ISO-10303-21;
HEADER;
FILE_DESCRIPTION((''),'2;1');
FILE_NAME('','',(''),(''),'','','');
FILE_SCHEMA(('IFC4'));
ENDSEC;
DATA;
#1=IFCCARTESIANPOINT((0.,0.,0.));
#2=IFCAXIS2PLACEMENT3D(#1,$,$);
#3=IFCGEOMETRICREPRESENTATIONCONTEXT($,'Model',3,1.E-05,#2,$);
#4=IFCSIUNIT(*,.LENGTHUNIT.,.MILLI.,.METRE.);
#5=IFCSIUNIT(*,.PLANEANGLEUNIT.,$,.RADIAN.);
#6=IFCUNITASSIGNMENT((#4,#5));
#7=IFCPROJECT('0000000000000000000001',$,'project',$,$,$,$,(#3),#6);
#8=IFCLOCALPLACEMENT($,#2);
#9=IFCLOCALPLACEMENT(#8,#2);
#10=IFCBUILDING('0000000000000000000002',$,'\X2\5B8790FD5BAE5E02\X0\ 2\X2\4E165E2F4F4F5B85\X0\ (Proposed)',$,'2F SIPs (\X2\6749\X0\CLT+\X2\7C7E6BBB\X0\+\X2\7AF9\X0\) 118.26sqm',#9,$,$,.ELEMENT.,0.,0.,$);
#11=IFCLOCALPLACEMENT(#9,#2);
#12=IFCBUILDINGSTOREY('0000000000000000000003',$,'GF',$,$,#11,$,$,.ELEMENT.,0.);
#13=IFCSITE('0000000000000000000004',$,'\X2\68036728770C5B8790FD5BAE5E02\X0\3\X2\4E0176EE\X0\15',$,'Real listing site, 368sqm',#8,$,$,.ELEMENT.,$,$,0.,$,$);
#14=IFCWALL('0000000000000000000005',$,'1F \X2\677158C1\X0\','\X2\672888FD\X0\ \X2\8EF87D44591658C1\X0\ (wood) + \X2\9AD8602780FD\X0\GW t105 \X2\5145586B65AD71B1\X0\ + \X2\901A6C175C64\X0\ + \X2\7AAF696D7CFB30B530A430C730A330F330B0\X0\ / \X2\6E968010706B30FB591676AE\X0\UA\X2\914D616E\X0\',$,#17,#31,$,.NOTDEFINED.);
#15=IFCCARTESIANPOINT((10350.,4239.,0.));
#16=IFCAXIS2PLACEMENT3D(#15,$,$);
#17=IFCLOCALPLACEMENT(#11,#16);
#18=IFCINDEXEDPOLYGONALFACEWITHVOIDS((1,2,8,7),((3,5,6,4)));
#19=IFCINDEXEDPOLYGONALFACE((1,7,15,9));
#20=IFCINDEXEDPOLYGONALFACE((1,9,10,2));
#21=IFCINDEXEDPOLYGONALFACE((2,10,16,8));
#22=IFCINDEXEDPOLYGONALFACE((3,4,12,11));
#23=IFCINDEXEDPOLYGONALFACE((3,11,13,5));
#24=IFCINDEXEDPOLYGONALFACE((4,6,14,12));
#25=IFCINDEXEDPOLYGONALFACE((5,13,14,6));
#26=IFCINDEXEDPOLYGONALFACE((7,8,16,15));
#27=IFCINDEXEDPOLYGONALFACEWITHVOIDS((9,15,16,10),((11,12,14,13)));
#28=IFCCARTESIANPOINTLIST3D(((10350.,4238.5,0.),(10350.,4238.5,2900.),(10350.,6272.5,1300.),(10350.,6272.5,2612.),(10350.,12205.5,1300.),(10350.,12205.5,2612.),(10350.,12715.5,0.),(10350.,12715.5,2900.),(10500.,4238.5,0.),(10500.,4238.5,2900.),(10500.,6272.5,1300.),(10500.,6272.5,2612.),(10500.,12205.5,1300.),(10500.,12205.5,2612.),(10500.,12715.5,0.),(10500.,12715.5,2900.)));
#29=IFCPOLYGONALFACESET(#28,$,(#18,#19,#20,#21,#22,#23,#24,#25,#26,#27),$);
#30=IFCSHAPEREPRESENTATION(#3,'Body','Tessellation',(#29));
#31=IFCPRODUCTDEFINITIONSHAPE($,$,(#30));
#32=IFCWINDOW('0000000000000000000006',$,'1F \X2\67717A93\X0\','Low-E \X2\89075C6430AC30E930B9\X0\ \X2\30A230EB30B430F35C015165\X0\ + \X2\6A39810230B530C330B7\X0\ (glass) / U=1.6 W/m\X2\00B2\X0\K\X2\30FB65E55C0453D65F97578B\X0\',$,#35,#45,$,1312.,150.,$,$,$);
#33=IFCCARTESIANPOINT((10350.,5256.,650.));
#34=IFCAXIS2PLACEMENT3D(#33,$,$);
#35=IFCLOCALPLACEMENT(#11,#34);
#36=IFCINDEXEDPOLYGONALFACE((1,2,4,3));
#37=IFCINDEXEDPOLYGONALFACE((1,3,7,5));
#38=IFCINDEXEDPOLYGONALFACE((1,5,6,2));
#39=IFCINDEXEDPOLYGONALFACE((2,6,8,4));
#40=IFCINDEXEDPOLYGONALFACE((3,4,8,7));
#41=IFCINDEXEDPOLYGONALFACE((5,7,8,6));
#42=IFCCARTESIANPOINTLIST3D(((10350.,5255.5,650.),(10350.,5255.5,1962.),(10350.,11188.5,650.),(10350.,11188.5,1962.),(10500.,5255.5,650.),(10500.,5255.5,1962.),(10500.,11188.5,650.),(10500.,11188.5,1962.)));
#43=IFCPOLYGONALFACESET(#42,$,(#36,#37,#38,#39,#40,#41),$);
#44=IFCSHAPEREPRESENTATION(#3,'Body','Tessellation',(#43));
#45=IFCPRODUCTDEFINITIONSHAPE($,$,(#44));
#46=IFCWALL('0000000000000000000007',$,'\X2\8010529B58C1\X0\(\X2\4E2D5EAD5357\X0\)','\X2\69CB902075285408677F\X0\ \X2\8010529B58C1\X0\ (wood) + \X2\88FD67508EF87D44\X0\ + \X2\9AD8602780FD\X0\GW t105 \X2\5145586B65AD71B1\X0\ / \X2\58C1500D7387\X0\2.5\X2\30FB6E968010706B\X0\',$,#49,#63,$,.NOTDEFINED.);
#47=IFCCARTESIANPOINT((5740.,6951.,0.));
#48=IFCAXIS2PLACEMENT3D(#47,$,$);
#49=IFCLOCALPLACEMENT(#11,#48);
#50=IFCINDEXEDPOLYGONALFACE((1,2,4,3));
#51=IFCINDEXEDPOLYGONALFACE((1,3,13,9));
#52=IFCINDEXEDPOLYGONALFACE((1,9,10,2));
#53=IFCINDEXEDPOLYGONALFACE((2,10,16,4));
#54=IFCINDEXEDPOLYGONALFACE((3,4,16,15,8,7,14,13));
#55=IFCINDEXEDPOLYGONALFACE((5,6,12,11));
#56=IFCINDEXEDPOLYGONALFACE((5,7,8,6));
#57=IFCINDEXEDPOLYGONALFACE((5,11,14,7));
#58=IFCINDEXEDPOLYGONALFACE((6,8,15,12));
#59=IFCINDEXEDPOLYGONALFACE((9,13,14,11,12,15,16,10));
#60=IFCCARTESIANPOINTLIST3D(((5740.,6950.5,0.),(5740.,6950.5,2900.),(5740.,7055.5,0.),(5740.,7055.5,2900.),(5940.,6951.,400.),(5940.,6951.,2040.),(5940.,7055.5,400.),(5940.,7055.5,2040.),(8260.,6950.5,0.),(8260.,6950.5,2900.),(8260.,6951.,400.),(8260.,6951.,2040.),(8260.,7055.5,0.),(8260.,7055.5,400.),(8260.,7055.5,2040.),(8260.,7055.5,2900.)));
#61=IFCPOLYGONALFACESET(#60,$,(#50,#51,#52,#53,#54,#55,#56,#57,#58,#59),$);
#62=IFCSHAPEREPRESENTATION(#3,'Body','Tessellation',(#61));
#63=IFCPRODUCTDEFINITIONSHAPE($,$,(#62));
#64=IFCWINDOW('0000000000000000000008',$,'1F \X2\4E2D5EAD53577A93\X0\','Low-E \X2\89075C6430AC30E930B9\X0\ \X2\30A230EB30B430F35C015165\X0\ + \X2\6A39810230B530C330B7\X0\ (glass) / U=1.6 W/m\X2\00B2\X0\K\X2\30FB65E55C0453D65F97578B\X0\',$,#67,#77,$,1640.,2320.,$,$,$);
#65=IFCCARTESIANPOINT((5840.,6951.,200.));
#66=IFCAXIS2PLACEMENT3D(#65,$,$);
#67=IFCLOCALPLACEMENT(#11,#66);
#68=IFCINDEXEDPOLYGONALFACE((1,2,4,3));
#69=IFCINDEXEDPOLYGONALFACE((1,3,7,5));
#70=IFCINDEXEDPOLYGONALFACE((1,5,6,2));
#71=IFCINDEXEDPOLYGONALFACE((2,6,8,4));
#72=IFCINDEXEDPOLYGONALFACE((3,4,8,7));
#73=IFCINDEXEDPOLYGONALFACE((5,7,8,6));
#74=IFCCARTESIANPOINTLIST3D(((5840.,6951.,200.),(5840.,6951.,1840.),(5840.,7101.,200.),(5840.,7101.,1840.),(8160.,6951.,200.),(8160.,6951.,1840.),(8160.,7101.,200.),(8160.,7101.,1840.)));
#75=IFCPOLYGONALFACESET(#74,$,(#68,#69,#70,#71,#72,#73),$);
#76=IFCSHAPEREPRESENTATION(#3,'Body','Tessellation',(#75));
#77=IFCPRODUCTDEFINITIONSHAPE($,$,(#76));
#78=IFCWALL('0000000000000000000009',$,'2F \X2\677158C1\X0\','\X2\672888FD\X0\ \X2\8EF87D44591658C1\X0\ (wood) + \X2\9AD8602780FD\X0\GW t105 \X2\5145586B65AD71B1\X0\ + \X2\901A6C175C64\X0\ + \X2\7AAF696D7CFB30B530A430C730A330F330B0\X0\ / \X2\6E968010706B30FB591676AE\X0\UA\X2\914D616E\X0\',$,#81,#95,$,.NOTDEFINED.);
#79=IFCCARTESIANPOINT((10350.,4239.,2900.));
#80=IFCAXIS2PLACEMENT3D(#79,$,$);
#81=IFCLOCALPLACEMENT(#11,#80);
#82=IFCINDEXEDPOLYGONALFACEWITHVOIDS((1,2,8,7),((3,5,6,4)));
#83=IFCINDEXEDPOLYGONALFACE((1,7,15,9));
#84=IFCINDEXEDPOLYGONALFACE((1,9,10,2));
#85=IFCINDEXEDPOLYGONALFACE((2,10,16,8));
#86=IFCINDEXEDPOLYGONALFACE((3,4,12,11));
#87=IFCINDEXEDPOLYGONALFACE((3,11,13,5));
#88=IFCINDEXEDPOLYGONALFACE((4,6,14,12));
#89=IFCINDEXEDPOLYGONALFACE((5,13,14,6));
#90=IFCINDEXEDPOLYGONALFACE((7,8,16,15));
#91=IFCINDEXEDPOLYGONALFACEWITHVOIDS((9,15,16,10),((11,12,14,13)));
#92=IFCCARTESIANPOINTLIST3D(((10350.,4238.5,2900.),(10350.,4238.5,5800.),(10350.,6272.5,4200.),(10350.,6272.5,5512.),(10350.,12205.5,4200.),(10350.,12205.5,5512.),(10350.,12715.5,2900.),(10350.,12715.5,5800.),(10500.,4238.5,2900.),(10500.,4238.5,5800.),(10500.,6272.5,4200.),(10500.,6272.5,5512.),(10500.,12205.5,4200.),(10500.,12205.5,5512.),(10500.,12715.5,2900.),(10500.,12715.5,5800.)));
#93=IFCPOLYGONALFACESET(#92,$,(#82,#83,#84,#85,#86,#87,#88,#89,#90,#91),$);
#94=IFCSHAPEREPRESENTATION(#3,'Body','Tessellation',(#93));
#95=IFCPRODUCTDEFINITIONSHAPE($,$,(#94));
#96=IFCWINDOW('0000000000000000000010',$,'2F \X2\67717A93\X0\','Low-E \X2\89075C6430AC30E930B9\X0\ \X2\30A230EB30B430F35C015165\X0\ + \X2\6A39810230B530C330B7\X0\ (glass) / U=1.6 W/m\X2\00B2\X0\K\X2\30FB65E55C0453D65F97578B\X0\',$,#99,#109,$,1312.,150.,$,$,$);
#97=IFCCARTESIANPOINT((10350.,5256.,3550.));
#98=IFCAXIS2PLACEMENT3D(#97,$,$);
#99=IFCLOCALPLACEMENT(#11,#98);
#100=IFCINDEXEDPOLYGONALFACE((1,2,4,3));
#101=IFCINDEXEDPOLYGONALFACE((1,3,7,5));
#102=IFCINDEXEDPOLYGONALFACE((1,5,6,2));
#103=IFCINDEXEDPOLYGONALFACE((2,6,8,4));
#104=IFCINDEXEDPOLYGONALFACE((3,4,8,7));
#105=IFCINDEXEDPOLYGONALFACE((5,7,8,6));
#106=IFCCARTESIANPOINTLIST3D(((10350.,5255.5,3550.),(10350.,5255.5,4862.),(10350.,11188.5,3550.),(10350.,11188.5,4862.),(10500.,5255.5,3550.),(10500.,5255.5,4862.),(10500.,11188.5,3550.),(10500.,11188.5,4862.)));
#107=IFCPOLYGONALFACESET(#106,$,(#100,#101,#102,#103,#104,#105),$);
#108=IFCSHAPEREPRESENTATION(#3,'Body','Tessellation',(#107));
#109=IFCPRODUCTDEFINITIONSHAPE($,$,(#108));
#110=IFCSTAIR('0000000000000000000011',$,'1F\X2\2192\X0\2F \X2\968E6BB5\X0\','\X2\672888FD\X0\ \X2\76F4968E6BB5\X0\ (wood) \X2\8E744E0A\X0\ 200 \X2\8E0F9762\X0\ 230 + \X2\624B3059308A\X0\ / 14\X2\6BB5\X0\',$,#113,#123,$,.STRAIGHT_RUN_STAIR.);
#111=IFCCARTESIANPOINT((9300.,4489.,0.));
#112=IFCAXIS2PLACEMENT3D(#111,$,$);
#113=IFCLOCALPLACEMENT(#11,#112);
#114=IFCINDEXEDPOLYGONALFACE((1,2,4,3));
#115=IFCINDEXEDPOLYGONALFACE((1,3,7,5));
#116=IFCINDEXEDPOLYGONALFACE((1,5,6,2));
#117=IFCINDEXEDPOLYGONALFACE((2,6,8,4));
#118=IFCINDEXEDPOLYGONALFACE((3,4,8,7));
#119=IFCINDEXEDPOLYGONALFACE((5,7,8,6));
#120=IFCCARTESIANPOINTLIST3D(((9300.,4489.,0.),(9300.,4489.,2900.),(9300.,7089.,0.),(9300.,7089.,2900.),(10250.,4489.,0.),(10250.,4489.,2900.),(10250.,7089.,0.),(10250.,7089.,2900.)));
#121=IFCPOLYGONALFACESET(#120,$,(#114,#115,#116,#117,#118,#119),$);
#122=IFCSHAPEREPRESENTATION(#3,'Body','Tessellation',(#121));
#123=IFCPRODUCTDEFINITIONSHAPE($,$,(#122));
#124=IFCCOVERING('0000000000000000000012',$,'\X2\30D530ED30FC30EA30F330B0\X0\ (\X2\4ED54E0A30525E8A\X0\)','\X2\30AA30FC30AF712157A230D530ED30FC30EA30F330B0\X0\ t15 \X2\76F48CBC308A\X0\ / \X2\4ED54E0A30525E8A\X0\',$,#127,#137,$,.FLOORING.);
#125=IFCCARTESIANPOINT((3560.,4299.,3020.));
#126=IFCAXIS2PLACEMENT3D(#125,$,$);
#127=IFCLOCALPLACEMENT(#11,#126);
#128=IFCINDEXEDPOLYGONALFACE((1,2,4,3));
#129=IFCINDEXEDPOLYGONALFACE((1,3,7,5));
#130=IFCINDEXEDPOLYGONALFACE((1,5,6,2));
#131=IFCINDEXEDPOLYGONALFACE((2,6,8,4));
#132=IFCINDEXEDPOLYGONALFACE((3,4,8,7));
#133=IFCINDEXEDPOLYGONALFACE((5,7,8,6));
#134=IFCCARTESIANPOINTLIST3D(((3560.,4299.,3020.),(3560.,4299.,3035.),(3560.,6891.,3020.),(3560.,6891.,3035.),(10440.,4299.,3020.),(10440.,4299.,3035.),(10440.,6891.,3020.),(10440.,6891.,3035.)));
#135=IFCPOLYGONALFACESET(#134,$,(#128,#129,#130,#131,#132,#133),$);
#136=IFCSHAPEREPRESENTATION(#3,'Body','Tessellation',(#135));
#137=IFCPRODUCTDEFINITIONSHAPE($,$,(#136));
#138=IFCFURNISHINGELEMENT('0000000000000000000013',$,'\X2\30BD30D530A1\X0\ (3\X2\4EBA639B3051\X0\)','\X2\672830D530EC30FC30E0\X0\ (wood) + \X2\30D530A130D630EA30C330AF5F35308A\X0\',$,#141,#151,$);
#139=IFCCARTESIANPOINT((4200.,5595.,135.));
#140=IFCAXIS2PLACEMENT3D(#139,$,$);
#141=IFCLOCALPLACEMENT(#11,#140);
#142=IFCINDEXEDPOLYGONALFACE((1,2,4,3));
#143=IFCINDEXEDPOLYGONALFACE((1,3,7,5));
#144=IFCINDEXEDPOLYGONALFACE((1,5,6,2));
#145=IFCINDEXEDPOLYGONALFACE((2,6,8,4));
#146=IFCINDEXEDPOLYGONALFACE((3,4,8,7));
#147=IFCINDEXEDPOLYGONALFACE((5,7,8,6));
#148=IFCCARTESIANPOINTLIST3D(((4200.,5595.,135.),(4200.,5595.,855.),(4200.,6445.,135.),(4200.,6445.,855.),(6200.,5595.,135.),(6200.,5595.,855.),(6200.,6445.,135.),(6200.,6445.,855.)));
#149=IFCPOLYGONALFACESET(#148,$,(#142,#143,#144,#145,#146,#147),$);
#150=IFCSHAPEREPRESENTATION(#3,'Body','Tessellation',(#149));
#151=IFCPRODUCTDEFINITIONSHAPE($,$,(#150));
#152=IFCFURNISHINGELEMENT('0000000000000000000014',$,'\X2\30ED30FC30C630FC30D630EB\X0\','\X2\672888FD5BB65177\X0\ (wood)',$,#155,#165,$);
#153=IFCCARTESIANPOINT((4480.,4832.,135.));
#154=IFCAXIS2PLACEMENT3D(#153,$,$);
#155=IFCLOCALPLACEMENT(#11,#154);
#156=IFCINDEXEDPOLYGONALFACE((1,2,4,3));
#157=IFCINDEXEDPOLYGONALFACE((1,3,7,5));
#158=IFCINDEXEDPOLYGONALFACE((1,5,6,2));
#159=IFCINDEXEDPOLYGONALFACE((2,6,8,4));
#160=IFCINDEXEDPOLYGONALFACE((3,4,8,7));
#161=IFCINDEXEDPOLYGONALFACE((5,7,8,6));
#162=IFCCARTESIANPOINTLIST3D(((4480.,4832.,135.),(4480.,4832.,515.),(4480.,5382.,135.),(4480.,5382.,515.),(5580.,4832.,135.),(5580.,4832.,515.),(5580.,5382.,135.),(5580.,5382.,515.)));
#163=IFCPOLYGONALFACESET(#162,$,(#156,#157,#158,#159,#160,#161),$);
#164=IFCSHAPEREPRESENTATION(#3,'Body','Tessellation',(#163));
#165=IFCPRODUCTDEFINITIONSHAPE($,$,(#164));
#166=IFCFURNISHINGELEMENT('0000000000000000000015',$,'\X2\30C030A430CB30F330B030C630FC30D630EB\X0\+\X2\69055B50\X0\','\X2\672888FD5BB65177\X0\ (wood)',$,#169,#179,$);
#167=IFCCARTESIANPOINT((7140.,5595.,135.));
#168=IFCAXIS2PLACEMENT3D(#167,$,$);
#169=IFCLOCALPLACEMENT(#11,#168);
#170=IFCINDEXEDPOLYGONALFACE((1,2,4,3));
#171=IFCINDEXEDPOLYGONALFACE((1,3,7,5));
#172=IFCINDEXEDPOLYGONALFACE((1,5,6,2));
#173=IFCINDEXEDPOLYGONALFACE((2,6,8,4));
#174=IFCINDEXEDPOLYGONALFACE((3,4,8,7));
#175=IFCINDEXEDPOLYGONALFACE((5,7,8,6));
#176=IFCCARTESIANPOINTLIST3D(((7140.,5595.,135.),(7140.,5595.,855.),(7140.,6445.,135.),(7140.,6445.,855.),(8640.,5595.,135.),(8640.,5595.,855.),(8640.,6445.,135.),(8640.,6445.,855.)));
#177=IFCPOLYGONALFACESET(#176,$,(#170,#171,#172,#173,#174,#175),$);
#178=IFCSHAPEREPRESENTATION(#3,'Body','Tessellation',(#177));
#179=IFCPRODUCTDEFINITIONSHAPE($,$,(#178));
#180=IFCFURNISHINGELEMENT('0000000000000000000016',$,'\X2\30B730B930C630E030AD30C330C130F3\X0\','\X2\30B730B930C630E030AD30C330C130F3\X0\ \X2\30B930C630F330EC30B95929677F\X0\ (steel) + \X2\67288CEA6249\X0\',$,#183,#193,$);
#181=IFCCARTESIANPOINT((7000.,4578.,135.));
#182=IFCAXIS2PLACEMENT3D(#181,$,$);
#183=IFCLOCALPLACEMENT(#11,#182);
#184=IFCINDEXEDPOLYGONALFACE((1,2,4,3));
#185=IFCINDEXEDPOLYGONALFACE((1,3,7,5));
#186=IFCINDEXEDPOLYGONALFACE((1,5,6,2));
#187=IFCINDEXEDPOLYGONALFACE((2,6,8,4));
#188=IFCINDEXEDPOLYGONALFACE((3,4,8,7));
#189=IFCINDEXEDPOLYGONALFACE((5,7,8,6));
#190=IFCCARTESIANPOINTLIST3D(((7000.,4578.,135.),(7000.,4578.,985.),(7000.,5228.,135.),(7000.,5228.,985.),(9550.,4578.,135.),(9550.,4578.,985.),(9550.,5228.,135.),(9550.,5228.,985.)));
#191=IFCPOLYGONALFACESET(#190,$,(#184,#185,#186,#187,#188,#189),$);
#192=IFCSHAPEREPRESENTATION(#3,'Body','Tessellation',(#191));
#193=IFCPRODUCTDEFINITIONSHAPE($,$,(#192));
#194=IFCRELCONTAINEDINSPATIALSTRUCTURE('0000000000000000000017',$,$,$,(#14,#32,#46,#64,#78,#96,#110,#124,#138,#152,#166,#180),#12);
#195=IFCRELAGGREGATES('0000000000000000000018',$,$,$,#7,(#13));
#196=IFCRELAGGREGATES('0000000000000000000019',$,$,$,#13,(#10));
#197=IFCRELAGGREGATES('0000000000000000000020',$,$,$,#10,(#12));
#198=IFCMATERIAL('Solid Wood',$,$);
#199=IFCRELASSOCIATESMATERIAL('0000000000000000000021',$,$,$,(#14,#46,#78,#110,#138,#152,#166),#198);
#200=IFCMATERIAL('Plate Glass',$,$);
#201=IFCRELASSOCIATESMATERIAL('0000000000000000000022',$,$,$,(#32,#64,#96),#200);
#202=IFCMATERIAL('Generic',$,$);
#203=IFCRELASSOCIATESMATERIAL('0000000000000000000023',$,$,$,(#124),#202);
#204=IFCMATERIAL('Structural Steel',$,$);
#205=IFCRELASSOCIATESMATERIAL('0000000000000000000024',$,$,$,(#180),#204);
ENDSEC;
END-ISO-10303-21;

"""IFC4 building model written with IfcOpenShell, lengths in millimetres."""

from ifc_helpers import new_model, si_unit, frame, frame_2d, origin, place, context, project, spatial, rectangle, extrude, material, element, fill, save


model = new_model("IFC4")

# Units and contexts
model_context = context("Model", 3, precision=1e-05, world=origin())
ifc_project = project(units=[si_unit("LENGTHUNIT", "METRE", prefix="MILLI"), si_unit("PLANEANGLEUNIT", "RADIAN")], contexts=[model_context])

# Site, building, storey
site_placement = place(None, origin())
site = spatial("IfcSite", under=ifc_project, at=site_placement, Name="栃木県宇都宮市3丁目15", ObjectType="Real listing site, 368sqm", CompositionType="ELEMENT", RefElevation=0.0)
building_placement = place(site_placement, origin())
building = spatial("IfcBuilding", under=site, at=building_placement, Name="宇都宮市 2世帯住宅 (Proposed)", ObjectType="2F SIPs (杉CLT+籾殻+竹) 118.26sqm", CompositionType="ELEMENT", ElevationOfRefHeight=0.0, ElevationOfTerrain=0.0)
storey_placement = place(building_placement, origin())
storey = spatial("IfcBuildingStorey", under=building, at=storey_placement, Name="GF", CompositionType="ELEMENT", Elevation=0.0)

# Shared definitions
ifc_material_1 = material(Name="Solid Wood")

# Walls, openings, windows
wall_1_placement = place(storey_placement, frame((10350.0, 4239.0, 0.0)))
wall_1 = element("IfcWall", 1, at=wall_1_placement, inside=storey, material=ifc_material_1, Name="1F 東壁", Description="木製 軸組外壁 (wood) + 高性能GW t105 充填断熱 + 通気層 + 窯業系サイディング / 準耐火・外皮UA配慮", PredefinedType="NOTDEFINED", context=model_context, shape_type="SweptSolid", body=[
    extrude(rectangle(XDim=150.0, YDim=8477.0, at=frame_2d((75.0, 4238.0))), frame((10350.0, 4239.0, 0.0)), (0.0, 0.0, 1.0), 2900.0),
])
opening_1_placement = place(storey_placement, frame((10350.0, 5256.0, 650.0)))
opening_1 = element("IfcOpeningElement", 2, at=opening_1_placement, cuts=wall_1, PredefinedType="NOTDEFINED", context=model_context, shape_type="SweptSolid", body=[
    extrude(rectangle(XDim=150.0, YDim=5933.0, at=frame_2d((75.0, 2966.0))), frame((10350.0, 5256.0, 650.0)), (0.0, 0.0, 1.0), 1312.0),
])
ifc_material_2 = material(Name="Plate Glass")
window_1_placement = place(storey_placement, frame((10350.0, 5256.0, 650.0)))
window_1 = element("IfcWindow", 3, at=window_1_placement, inside=storey, material=ifc_material_2, Name="1F 東窓", Description="Low-E 複層ガラス アルゴン封入 + 樹脂サッシ (glass) / U=1.6 W/m²K・日射取得型", OverallHeight=1312.0, OverallWidth=150.0, context=model_context, shape_type="SweptSolid", body=[
    extrude(rectangle(XDim=150.0, YDim=5933.0, at=frame_2d((75.0, 2966.0))), frame((10350.0, 5256.0, 650.0)), (0.0, 0.0, 1.0), 1312.0),
])
fill(opening_1, window_1)
wall_2_placement = place(storey_placement, frame((5740.0, 6951.0, 0.0)))
wall_2 = element("IfcWall", 4, at=wall_2_placement, inside=storey, material=ifc_material_1, Name="耐力壁(中庭南)", Description="構造用合板 耐力壁 (wood) + 製材軸組 + 高性能GW t105 充填断熱 / 壁倍率2.5・準耐火", PredefinedType="NOTDEFINED", context=model_context, shape_type="SweptSolid", body=[
    extrude(rectangle(XDim=2520.0, YDim=105.0, at=frame_2d((1260.0, 52.0))), frame((5740.0, 6951.0, 0.0)), (0.0, 0.0, 1.0), 2900.0),
])
opening_2_placement = place(storey_placement, frame((5840.0, 6951.0, 200.0)))
opening_2 = element("IfcOpeningElement", 5, at=opening_2_placement, cuts=wall_2, PredefinedType="NOTDEFINED", context=model_context, shape_type="SweptSolid", body=[
    extrude(rectangle(XDim=2320.0, YDim=150.0, at=frame_2d((1160.0, 75.0))), frame((5840.0, 6951.0, 200.0)), (0.0, 0.0, 1.0), 1640.0),
])
window_2_placement = place(storey_placement, frame((5840.0, 6951.0, 200.0)))
window_2 = element("IfcWindow", 6, at=window_2_placement, inside=storey, material=ifc_material_2, Name="1F 中庭南窓", Description="Low-E 複層ガラス アルゴン封入 + 樹脂サッシ (glass) / U=1.6 W/m²K・日射取得型", OverallHeight=1640.0, OverallWidth=2320.0, context=model_context, shape_type="SweptSolid", body=[
    extrude(rectangle(XDim=2320.0, YDim=150.0, at=frame_2d((1160.0, 75.0))), frame((5840.0, 6951.0, 200.0)), (0.0, 0.0, 1.0), 1640.0),
])
fill(opening_2, window_2)

# Wall, opening, window
wall_3_placement = place(storey_placement, frame((10350.0, 4239.0, 2900.0)))
wall_3 = element("IfcWall", 7, at=wall_3_placement, inside=storey, material=ifc_material_1, Name="2F 東壁", Description="木製 軸組外壁 (wood) + 高性能GW t105 充填断熱 + 通気層 + 窯業系サイディング / 準耐火・外皮UA配慮", PredefinedType="NOTDEFINED", context=model_context, shape_type="SweptSolid", body=[
    extrude(rectangle(XDim=150.0, YDim=8477.0, at=frame_2d((75.0, 4238.0))), frame((10350.0, 4239.0, 2900.0)), (0.0, 0.0, 1.0), 2900.0),
])
opening_3_placement = place(storey_placement, frame((10350.0, 5256.0, 3550.0)))
opening_3 = element("IfcOpeningElement", 8, at=opening_3_placement, cuts=wall_3, PredefinedType="NOTDEFINED", context=model_context, shape_type="SweptSolid", body=[
    extrude(rectangle(XDim=150.0, YDim=5933.0, at=frame_2d((75.0, 2966.0))), frame((10350.0, 5256.0, 3550.0)), (0.0, 0.0, 1.0), 1312.0),
])
window_3_placement = place(storey_placement, frame((10350.0, 5256.0, 3550.0)))
window_3 = element("IfcWindow", 9, at=window_3_placement, inside=storey, material=ifc_material_2, Name="2F 東窓", Description="Low-E 複層ガラス アルゴン封入 + 樹脂サッシ (glass) / U=1.6 W/m²K・日射取得型", OverallHeight=1312.0, OverallWidth=150.0, context=model_context, shape_type="SweptSolid", body=[
    extrude(rectangle(XDim=150.0, YDim=5933.0, at=frame_2d((75.0, 2966.0))), frame((10350.0, 5256.0, 3550.0)), (0.0, 0.0, 1.0), 1312.0),
])
fill(opening_3, window_3)

# Stair
stair_placement = place(storey_placement, frame((9300.0, 4489.0, 0.0)))
element("IfcStair", 10, at=stair_placement, inside=storey, material=ifc_material_1, Name="1F→2F 階段", Description="木製 直階段 (wood) 蹴上 200 踏面 230 + 手すり / 14段", PredefinedType="STRAIGHT_RUN_STAIR", context=model_context, shape_type="SweptSolid", body=[
    extrude(rectangle(XDim=950.0, YDim=2600.0, at=frame_2d((475.0, 1300.0))), frame((9300.0, 4489.0, 0.0)), (0.0, 0.0, 1.0), 2900.0),
])

# Covering
ifc_material_3 = material(Name="Generic")
covering_placement = place(storey_placement, frame((3560.0, 4299.0, 3020.0)))
element("IfcCovering", 11, at=covering_placement, inside=storey, material=ifc_material_3, Name="フローリング (仕上げ床)", Description="オーク無垢フローリング t15 直貼り / 仕上げ床", PredefinedType="FLOORING", context=model_context, shape_type="SweptSolid", body=[
    extrude(rectangle(XDim=6880.0, YDim=2592.0, at=frame_2d((3440.0, 1296.0))), frame((3560.0, 4299.0, 3020.0)), (0.0, 0.0, 1.0), 15.0),
])

# Furnishing elements
furnishing_1_placement = place(storey_placement, frame((4200.0, 5595.0, 135.0)))
element("IfcFurnishingElement", 12, at=furnishing_1_placement, inside=storey, material=ifc_material_1, Name="ソファ (3人掛け)", Description="木フレーム (wood) + ファブリック張り", context=model_context, shape_type="SweptSolid", body=[
    extrude(rectangle(XDim=2000.0, YDim=850.0, at=frame_2d((1000.0, 425.0))), frame((4200.0, 5595.0, 135.0)), (0.0, 0.0, 1.0), 720.0),
])
furnishing_2_placement = place(storey_placement, frame((4480.0, 4832.0, 135.0)))
element("IfcFurnishingElement", 13, at=furnishing_2_placement, inside=storey, material=ifc_material_1, Name="ローテーブル", Description="木製家具 (wood)", context=model_context, shape_type="SweptSolid", body=[
    extrude(rectangle(XDim=1100.0, YDim=550.0, at=frame_2d((550.0, 275.0))), frame((4480.0, 4832.0, 135.0)), (0.0, 0.0, 1.0), 380.0),
])
furnishing_3_placement = place(storey_placement, frame((7140.0, 5595.0, 135.0)))
element("IfcFurnishingElement", 14, at=furnishing_3_placement, inside=storey, material=ifc_material_1, Name="ダイニングテーブル+椅子", Description="木製家具 (wood)", context=model_context, shape_type="SweptSolid", body=[
    extrude(rectangle(XDim=1500.0, YDim=850.0, at=frame_2d((750.0, 425.0))), frame((7140.0, 5595.0, 135.0)), (0.0, 0.0, 1.0), 720.0),
])
ifc_material_4 = material(Name="Structural Steel")
furnishing_4_placement = place(storey_placement, frame((7000.0, 4578.0, 135.0)))
element("IfcFurnishingElement", 15, at=furnishing_4_placement, inside=storey, material=ifc_material_4, Name="システムキッチン", Description="システムキッチン ステンレス天板 (steel) + 木質扉", context=model_context, shape_type="SweptSolid", body=[
    extrude(rectangle(XDim=2550.0, YDim=650.0, at=frame_2d((1275.0, 325.0))), frame((7000.0, 4578.0, 135.0)), (0.0, 0.0, 1.0), 850.0),
])

save(model, "model.ifc")
